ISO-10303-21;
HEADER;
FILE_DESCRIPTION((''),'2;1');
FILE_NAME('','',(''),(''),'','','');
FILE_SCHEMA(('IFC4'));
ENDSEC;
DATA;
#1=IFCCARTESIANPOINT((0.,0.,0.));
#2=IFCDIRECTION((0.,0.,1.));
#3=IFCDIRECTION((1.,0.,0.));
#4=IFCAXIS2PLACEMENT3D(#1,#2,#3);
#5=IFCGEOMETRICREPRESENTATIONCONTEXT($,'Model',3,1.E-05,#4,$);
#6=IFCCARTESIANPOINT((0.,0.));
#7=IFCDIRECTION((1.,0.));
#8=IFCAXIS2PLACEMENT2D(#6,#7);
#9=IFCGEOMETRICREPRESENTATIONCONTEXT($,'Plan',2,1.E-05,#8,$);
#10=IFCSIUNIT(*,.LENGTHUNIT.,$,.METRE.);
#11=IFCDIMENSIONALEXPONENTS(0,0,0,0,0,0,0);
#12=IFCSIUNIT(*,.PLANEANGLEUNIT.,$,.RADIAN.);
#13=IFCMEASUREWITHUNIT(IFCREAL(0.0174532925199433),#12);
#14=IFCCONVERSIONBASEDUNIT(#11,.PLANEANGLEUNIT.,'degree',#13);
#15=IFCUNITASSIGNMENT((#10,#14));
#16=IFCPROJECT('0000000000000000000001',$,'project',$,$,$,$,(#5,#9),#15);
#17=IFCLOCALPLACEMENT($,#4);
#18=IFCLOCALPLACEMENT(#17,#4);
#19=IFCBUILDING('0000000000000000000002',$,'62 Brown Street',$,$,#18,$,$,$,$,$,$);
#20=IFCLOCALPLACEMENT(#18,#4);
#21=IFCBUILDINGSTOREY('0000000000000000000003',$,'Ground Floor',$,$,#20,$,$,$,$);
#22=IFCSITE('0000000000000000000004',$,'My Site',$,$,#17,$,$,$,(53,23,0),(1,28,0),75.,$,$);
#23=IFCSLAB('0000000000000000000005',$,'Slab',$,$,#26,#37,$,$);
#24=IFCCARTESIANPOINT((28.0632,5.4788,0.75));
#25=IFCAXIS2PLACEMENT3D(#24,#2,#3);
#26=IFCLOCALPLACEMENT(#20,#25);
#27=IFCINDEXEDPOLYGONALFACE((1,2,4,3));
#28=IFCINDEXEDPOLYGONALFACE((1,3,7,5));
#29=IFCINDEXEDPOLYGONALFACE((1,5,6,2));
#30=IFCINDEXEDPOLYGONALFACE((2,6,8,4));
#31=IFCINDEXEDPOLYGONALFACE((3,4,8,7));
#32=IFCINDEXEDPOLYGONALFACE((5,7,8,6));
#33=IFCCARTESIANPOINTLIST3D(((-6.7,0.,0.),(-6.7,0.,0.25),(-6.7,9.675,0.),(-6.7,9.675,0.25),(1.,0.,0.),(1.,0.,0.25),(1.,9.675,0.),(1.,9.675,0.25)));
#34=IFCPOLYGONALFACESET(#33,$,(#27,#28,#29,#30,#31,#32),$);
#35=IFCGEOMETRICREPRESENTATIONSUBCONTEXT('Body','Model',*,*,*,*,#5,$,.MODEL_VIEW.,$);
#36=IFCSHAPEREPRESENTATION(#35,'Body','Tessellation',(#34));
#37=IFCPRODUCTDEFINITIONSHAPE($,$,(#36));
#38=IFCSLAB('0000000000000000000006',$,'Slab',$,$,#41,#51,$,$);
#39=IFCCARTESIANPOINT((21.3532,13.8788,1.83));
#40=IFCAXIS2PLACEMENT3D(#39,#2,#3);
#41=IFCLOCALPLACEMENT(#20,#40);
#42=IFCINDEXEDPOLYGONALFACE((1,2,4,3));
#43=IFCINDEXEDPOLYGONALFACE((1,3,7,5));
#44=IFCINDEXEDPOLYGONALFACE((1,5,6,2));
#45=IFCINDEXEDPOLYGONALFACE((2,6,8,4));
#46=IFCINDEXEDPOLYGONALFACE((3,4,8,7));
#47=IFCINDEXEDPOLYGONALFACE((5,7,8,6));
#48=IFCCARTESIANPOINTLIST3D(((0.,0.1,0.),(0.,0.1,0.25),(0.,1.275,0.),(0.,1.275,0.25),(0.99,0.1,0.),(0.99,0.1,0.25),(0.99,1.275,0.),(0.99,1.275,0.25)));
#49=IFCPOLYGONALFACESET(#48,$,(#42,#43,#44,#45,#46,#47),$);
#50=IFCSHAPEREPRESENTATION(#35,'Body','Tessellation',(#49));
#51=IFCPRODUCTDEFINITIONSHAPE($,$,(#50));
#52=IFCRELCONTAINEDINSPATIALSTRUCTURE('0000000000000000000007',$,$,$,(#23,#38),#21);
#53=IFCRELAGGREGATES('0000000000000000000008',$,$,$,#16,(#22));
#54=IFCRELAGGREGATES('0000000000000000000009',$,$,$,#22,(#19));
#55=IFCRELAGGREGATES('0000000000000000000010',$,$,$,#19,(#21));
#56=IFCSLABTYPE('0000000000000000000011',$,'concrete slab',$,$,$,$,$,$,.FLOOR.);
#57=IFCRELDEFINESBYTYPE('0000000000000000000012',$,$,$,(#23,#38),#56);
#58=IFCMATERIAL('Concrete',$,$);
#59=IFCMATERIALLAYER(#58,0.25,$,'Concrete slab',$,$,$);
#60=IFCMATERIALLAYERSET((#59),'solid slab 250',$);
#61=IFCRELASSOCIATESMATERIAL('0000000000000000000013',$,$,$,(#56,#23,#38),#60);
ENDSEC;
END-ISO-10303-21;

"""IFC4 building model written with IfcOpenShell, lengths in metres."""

from ifc_helpers import new_model, entity, si_unit, converted_unit, frame, origin_with_axes, origin_2d_with_axis, place, context, subcontext, project, spatial, line, indexed_curve, outline, extrude, material, layer, layer_set, layer_usage, type_object, element, save


model = new_model("IFC4")

# Units and contexts
model_context = context("Model", 3, precision=1e-05, world=origin_with_axes())
plan_context = context("Plan", 2, precision=1e-05, world=origin_2d_with_axis())
body_context_1 = subcontext(model_context, "Body", "Model", "MODEL_VIEW")
ifc_project = project(units=[si_unit("LENGTHUNIT", "METRE"), converted_unit("PLANEANGLEUNIT", "degree", entity("IfcReal", 0.0174532925199433), si_unit("PLANEANGLEUNIT", "RADIAN"), dimensions=[0, 0, 0, 0, 0, 0, 0])], contexts=[model_context, plan_context])

# Site, building, storey
site_placement = place(None, origin_with_axes())
site = spatial("IfcSite", under=ifc_project, at=site_placement, Name="My Site", RefLatitude=(53, 23, 0), RefLongitude=(1, 28, 0), RefElevation=75.0)
building_placement = place(site_placement, origin_with_axes())
building = spatial("IfcBuilding", under=site, at=building_placement, Name="62 Brown Street")
storey_placement = place(building_placement, origin_with_axes())
storey = spatial("IfcBuildingStorey", under=building, at=storey_placement, Name="Ground Floor")

# Shared definitions
ifc_material_1 = material(Name="Concrete")

# Slabs
ifc_layer_1 = layer(ifc_material_1, 0.25, Name="Concrete slab")
ifc_layer_set_1 = layer_set([ifc_layer_1], Name="solid slab 250")
slab_type = type_object("IfcSlabType", Name="concrete slab", PredefinedType="FLOOR", material=ifc_layer_set_1)
ifc_layer_usage_1 = layer_usage(ifc_layer_set_1, "AXIS3", "POSITIVE", 0.0)
slab_1_placement = place(storey_placement, frame((28.0632, 5.4788, 0.75), z_axis=(0.0, 0.0, 1.0), x_axis=(1.0, 0.0, 0.0)))
element("IfcSlab", 1, at=slab_1_placement, inside=storey, type_object=slab_type, material=ifc_layer_usage_1, Name="Slab", context=body_context_1, shape_type="SweptSolid", body=[
    extrude(outline(indexed_curve([(1.0, 9.675), (-6.7, 9.675), (-6.7, 0.0), (1.0, 0.0)], segments=[line(3, 2), line(2, 1), line(1, 4), line(4, 3)], self_intersect=False)), None, (0.0, 0.0, 1.0), 0.25),
])
ifc_layer_usage_2 = layer_usage(ifc_layer_set_1, "AXIS3", "POSITIVE", 0.0)
slab_2_placement = place(storey_placement, frame((21.3532, 13.8788, 1.83), z_axis=(0.0, 0.0, 1.0), x_axis=(1.0, 0.0, 0.0)))
element("IfcSlab", 2, at=slab_2_placement, inside=storey, type_object=slab_type, material=ifc_layer_usage_2, Name="Slab", context=body_context_1, shape_type="SweptSolid", body=[
    extrude(outline(indexed_curve([(0.99, 1.275), (0.99, 0.1), (0.0, 0.1), (0.0, 1.275)], segments=[line(3, 2), line(2, 1), line(1, 4), line(4, 3)], self_intersect=False)), None, (0.0, 0.0, 1.0), 0.25),
])

save(model, "model.ifc")
